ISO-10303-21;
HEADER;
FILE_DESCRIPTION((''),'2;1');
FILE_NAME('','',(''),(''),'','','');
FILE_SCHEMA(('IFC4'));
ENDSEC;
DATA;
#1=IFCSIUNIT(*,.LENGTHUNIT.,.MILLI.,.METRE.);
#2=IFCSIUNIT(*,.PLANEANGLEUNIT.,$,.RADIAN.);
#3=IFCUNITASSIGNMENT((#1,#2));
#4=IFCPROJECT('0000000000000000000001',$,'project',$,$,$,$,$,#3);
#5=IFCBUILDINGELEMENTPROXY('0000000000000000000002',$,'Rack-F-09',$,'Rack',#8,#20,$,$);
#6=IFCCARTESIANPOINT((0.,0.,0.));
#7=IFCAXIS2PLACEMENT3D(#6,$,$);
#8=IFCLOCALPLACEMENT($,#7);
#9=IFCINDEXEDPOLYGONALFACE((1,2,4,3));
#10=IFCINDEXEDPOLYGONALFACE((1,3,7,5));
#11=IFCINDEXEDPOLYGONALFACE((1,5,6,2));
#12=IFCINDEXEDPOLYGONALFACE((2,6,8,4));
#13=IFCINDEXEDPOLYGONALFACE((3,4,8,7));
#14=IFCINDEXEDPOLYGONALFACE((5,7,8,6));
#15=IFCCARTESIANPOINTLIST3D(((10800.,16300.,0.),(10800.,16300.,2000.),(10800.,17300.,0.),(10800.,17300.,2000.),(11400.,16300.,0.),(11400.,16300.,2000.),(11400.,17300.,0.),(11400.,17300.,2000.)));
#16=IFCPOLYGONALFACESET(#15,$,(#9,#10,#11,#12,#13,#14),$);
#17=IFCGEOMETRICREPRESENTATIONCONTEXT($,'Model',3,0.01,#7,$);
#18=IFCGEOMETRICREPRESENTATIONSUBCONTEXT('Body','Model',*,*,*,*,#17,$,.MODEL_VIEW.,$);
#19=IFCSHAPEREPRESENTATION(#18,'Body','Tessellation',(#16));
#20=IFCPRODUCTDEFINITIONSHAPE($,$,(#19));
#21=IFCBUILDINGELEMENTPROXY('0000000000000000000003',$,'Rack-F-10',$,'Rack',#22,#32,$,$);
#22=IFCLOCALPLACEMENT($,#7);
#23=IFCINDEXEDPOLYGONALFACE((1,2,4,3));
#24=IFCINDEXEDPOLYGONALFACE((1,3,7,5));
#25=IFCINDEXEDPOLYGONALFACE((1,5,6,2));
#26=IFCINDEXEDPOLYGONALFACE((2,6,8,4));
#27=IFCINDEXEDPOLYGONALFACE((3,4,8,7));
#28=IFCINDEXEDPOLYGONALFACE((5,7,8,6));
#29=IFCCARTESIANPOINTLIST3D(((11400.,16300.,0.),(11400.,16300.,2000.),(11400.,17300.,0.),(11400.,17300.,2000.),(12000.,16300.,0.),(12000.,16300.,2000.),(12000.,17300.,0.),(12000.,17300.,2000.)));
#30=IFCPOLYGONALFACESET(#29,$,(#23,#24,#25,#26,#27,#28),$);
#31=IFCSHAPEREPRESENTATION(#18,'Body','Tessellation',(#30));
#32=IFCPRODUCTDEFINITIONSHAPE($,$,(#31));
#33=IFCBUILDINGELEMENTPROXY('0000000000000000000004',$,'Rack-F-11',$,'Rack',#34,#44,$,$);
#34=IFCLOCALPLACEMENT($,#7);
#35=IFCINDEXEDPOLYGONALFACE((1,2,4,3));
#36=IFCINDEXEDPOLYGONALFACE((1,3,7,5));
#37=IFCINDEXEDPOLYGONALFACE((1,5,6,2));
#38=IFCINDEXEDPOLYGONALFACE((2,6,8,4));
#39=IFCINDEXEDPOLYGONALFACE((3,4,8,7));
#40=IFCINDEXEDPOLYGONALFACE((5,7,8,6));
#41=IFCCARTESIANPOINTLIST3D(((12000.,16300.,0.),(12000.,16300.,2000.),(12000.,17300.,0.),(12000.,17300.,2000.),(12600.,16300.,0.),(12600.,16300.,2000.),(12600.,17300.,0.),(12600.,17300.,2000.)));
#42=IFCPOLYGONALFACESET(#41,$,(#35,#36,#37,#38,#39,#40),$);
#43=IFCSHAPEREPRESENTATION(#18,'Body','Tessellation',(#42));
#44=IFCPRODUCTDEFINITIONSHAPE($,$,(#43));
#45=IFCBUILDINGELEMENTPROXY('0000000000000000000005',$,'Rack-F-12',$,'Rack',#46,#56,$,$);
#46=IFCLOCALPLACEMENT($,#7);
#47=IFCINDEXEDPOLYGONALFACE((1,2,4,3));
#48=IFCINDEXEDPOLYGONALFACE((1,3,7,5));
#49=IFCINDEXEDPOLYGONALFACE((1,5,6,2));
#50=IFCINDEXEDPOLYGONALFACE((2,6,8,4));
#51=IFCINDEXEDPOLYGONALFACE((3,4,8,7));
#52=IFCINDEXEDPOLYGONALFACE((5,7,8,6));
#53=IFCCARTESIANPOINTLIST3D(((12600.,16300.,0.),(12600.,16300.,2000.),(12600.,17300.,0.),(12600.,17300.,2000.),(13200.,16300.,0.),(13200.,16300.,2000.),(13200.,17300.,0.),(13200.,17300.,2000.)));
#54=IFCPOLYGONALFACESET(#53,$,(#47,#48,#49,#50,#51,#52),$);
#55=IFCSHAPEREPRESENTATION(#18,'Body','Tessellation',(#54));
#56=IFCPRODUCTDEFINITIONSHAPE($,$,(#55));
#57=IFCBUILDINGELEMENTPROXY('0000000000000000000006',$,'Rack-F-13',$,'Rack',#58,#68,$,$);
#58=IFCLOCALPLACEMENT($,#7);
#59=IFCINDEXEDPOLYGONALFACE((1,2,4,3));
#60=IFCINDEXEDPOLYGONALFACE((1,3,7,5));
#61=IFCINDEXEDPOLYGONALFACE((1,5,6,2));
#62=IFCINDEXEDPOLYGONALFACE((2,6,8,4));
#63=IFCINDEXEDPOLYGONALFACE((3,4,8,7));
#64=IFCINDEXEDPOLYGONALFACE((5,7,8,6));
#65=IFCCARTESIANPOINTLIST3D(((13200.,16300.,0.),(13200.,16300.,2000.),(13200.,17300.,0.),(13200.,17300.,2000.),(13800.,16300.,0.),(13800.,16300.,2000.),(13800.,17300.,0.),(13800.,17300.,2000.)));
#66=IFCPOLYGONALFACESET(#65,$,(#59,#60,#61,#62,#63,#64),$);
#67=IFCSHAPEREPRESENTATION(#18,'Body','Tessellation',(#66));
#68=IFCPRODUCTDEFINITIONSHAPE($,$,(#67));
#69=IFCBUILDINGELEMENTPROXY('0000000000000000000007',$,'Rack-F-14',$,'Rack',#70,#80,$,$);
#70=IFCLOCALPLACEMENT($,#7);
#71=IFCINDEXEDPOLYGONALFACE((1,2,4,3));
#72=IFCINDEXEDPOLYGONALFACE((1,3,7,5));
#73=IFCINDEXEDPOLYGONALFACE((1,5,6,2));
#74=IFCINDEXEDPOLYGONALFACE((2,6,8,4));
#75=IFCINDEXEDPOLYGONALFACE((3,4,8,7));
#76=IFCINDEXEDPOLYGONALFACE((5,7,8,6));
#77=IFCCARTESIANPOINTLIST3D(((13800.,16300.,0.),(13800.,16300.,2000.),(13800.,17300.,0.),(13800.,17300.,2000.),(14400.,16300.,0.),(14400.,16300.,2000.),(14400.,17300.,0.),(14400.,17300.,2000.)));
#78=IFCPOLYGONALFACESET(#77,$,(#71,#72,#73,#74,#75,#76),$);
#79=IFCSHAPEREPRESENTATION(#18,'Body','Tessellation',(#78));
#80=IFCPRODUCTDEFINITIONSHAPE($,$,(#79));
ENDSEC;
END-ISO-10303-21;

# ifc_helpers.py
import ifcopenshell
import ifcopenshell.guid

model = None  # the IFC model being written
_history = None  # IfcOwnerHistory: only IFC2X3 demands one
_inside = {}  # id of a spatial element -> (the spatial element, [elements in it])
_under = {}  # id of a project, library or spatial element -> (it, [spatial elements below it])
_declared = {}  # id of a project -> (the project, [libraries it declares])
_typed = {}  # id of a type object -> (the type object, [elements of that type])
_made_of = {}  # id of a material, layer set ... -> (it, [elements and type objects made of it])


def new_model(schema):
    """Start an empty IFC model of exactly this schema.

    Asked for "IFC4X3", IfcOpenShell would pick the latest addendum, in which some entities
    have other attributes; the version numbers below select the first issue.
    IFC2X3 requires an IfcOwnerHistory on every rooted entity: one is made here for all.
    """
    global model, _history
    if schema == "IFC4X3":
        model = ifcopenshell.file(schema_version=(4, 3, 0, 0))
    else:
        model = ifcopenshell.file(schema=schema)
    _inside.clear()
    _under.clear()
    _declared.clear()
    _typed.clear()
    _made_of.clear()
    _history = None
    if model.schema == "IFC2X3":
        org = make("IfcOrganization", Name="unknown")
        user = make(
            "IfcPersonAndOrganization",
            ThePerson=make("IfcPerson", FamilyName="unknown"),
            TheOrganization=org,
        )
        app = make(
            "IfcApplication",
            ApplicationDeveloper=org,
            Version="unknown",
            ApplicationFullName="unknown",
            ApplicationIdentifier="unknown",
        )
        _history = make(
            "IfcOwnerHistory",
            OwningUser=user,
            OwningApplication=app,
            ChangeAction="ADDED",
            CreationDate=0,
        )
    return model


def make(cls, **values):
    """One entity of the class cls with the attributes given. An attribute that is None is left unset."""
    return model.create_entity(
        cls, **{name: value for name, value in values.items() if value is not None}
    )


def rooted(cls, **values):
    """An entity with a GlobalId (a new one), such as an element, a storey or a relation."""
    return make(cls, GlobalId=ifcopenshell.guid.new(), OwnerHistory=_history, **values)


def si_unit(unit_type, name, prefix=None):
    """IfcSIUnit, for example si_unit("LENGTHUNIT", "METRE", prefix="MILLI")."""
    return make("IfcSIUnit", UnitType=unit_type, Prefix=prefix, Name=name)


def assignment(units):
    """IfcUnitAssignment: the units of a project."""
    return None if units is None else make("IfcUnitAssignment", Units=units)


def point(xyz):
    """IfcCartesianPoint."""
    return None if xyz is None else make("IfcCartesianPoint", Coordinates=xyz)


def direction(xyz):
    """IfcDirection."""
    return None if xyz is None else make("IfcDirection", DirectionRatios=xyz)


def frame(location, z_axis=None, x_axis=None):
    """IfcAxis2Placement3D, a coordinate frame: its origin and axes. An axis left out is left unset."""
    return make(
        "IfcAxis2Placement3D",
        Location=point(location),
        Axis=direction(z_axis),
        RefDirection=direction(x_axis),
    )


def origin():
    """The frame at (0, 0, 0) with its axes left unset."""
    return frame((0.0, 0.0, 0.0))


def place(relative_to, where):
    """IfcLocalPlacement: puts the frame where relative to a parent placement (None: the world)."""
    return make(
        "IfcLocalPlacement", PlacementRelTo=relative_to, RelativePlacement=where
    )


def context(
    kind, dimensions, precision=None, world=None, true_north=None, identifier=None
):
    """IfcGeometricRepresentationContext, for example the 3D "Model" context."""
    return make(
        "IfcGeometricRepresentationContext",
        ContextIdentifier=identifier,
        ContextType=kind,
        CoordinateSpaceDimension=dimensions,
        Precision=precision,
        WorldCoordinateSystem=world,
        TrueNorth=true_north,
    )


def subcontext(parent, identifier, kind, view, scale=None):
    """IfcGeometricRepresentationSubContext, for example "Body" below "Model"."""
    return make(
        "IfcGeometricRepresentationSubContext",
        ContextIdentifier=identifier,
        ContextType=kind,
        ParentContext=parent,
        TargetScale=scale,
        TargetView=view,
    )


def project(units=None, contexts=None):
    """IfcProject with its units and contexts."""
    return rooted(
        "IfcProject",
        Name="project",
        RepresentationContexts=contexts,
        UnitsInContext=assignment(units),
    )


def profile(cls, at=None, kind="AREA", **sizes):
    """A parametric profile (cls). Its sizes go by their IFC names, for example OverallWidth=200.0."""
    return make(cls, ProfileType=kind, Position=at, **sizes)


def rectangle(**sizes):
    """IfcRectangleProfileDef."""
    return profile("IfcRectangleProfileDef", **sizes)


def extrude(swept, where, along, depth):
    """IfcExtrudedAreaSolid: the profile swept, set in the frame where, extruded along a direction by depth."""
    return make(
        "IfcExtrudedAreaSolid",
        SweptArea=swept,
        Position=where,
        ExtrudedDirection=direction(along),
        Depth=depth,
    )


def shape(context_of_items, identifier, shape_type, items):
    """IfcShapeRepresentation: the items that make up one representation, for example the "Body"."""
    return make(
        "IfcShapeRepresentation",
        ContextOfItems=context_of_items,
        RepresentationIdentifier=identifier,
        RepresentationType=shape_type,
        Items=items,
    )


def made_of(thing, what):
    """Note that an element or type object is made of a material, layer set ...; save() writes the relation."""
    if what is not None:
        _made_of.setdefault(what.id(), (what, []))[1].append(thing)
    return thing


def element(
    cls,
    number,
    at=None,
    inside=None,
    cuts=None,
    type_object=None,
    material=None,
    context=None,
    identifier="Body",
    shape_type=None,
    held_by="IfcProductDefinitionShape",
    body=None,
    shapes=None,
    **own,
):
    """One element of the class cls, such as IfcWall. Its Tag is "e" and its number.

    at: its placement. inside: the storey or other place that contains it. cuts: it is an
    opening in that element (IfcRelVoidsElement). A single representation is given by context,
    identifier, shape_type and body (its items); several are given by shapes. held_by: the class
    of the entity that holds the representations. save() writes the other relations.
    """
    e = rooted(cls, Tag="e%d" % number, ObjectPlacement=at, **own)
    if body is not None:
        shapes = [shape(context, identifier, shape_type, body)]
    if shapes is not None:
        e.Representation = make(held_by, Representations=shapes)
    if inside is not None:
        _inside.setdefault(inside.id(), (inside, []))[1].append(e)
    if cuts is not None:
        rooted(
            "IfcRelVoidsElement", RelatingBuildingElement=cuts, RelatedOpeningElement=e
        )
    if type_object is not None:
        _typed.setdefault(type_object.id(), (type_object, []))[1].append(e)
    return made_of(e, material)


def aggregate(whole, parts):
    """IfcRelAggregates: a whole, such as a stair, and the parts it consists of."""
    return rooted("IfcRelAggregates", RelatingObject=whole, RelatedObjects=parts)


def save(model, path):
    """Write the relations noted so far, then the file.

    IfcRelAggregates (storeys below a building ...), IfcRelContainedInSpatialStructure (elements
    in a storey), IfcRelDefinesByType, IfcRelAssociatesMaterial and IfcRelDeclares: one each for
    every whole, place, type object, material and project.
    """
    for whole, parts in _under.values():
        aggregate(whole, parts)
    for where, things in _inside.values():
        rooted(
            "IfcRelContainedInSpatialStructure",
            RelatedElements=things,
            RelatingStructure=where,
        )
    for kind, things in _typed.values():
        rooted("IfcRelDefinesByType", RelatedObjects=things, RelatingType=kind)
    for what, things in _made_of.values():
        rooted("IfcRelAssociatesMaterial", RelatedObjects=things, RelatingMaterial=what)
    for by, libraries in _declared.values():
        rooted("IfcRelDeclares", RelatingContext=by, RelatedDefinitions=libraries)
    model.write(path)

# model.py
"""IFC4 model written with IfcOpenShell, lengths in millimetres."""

from ifc_helpers import new_model, si_unit, frame, origin, place, context, subcontext, project, rectangle, extrude, element, save


model = new_model("IFC4")

# Units and contexts
model_context = context("Model", 3, precision=0.01, world=origin())
body_context = subcontext(model_context, "Body", "Model", "MODEL_VIEW")
ifc_project = project(units=[si_unit("LENGTHUNIT", "METRE", prefix="MILLI"), si_unit("PLANEANGLEUNIT", "RADIAN")])

# Shared definitions
placement = place(None, origin())

# Building element proxies
for number, where, name in (
    (1, (11100.0, 16800.0, 0.0), "Rack-F-09"),
    (2, (11700.0, 16800.0, 0.0), "Rack-F-10"),
    (3, (12300.0, 16800.0, 0.0), "Rack-F-11"),
    (4, (12900.0, 16800.0, 0.0), "Rack-F-12"),
    (5, (13500.0, 16800.0, 0.0), "Rack-F-13"),
    (6, (14100.0, 16800.0, 0.0), "Rack-F-14"),
):
    element("IfcBuildingElementProxy", number, at=place(placement, frame(where)), Name=name, ObjectType="Rack", context=body_context, shape_type="SweptSolid", body=[
        extrude(rectangle(XDim=600.0, YDim=1000.0), origin(), (0.0, 0.0, 1.0), 2000.0),
    ])

save(model, "model.ifc")
